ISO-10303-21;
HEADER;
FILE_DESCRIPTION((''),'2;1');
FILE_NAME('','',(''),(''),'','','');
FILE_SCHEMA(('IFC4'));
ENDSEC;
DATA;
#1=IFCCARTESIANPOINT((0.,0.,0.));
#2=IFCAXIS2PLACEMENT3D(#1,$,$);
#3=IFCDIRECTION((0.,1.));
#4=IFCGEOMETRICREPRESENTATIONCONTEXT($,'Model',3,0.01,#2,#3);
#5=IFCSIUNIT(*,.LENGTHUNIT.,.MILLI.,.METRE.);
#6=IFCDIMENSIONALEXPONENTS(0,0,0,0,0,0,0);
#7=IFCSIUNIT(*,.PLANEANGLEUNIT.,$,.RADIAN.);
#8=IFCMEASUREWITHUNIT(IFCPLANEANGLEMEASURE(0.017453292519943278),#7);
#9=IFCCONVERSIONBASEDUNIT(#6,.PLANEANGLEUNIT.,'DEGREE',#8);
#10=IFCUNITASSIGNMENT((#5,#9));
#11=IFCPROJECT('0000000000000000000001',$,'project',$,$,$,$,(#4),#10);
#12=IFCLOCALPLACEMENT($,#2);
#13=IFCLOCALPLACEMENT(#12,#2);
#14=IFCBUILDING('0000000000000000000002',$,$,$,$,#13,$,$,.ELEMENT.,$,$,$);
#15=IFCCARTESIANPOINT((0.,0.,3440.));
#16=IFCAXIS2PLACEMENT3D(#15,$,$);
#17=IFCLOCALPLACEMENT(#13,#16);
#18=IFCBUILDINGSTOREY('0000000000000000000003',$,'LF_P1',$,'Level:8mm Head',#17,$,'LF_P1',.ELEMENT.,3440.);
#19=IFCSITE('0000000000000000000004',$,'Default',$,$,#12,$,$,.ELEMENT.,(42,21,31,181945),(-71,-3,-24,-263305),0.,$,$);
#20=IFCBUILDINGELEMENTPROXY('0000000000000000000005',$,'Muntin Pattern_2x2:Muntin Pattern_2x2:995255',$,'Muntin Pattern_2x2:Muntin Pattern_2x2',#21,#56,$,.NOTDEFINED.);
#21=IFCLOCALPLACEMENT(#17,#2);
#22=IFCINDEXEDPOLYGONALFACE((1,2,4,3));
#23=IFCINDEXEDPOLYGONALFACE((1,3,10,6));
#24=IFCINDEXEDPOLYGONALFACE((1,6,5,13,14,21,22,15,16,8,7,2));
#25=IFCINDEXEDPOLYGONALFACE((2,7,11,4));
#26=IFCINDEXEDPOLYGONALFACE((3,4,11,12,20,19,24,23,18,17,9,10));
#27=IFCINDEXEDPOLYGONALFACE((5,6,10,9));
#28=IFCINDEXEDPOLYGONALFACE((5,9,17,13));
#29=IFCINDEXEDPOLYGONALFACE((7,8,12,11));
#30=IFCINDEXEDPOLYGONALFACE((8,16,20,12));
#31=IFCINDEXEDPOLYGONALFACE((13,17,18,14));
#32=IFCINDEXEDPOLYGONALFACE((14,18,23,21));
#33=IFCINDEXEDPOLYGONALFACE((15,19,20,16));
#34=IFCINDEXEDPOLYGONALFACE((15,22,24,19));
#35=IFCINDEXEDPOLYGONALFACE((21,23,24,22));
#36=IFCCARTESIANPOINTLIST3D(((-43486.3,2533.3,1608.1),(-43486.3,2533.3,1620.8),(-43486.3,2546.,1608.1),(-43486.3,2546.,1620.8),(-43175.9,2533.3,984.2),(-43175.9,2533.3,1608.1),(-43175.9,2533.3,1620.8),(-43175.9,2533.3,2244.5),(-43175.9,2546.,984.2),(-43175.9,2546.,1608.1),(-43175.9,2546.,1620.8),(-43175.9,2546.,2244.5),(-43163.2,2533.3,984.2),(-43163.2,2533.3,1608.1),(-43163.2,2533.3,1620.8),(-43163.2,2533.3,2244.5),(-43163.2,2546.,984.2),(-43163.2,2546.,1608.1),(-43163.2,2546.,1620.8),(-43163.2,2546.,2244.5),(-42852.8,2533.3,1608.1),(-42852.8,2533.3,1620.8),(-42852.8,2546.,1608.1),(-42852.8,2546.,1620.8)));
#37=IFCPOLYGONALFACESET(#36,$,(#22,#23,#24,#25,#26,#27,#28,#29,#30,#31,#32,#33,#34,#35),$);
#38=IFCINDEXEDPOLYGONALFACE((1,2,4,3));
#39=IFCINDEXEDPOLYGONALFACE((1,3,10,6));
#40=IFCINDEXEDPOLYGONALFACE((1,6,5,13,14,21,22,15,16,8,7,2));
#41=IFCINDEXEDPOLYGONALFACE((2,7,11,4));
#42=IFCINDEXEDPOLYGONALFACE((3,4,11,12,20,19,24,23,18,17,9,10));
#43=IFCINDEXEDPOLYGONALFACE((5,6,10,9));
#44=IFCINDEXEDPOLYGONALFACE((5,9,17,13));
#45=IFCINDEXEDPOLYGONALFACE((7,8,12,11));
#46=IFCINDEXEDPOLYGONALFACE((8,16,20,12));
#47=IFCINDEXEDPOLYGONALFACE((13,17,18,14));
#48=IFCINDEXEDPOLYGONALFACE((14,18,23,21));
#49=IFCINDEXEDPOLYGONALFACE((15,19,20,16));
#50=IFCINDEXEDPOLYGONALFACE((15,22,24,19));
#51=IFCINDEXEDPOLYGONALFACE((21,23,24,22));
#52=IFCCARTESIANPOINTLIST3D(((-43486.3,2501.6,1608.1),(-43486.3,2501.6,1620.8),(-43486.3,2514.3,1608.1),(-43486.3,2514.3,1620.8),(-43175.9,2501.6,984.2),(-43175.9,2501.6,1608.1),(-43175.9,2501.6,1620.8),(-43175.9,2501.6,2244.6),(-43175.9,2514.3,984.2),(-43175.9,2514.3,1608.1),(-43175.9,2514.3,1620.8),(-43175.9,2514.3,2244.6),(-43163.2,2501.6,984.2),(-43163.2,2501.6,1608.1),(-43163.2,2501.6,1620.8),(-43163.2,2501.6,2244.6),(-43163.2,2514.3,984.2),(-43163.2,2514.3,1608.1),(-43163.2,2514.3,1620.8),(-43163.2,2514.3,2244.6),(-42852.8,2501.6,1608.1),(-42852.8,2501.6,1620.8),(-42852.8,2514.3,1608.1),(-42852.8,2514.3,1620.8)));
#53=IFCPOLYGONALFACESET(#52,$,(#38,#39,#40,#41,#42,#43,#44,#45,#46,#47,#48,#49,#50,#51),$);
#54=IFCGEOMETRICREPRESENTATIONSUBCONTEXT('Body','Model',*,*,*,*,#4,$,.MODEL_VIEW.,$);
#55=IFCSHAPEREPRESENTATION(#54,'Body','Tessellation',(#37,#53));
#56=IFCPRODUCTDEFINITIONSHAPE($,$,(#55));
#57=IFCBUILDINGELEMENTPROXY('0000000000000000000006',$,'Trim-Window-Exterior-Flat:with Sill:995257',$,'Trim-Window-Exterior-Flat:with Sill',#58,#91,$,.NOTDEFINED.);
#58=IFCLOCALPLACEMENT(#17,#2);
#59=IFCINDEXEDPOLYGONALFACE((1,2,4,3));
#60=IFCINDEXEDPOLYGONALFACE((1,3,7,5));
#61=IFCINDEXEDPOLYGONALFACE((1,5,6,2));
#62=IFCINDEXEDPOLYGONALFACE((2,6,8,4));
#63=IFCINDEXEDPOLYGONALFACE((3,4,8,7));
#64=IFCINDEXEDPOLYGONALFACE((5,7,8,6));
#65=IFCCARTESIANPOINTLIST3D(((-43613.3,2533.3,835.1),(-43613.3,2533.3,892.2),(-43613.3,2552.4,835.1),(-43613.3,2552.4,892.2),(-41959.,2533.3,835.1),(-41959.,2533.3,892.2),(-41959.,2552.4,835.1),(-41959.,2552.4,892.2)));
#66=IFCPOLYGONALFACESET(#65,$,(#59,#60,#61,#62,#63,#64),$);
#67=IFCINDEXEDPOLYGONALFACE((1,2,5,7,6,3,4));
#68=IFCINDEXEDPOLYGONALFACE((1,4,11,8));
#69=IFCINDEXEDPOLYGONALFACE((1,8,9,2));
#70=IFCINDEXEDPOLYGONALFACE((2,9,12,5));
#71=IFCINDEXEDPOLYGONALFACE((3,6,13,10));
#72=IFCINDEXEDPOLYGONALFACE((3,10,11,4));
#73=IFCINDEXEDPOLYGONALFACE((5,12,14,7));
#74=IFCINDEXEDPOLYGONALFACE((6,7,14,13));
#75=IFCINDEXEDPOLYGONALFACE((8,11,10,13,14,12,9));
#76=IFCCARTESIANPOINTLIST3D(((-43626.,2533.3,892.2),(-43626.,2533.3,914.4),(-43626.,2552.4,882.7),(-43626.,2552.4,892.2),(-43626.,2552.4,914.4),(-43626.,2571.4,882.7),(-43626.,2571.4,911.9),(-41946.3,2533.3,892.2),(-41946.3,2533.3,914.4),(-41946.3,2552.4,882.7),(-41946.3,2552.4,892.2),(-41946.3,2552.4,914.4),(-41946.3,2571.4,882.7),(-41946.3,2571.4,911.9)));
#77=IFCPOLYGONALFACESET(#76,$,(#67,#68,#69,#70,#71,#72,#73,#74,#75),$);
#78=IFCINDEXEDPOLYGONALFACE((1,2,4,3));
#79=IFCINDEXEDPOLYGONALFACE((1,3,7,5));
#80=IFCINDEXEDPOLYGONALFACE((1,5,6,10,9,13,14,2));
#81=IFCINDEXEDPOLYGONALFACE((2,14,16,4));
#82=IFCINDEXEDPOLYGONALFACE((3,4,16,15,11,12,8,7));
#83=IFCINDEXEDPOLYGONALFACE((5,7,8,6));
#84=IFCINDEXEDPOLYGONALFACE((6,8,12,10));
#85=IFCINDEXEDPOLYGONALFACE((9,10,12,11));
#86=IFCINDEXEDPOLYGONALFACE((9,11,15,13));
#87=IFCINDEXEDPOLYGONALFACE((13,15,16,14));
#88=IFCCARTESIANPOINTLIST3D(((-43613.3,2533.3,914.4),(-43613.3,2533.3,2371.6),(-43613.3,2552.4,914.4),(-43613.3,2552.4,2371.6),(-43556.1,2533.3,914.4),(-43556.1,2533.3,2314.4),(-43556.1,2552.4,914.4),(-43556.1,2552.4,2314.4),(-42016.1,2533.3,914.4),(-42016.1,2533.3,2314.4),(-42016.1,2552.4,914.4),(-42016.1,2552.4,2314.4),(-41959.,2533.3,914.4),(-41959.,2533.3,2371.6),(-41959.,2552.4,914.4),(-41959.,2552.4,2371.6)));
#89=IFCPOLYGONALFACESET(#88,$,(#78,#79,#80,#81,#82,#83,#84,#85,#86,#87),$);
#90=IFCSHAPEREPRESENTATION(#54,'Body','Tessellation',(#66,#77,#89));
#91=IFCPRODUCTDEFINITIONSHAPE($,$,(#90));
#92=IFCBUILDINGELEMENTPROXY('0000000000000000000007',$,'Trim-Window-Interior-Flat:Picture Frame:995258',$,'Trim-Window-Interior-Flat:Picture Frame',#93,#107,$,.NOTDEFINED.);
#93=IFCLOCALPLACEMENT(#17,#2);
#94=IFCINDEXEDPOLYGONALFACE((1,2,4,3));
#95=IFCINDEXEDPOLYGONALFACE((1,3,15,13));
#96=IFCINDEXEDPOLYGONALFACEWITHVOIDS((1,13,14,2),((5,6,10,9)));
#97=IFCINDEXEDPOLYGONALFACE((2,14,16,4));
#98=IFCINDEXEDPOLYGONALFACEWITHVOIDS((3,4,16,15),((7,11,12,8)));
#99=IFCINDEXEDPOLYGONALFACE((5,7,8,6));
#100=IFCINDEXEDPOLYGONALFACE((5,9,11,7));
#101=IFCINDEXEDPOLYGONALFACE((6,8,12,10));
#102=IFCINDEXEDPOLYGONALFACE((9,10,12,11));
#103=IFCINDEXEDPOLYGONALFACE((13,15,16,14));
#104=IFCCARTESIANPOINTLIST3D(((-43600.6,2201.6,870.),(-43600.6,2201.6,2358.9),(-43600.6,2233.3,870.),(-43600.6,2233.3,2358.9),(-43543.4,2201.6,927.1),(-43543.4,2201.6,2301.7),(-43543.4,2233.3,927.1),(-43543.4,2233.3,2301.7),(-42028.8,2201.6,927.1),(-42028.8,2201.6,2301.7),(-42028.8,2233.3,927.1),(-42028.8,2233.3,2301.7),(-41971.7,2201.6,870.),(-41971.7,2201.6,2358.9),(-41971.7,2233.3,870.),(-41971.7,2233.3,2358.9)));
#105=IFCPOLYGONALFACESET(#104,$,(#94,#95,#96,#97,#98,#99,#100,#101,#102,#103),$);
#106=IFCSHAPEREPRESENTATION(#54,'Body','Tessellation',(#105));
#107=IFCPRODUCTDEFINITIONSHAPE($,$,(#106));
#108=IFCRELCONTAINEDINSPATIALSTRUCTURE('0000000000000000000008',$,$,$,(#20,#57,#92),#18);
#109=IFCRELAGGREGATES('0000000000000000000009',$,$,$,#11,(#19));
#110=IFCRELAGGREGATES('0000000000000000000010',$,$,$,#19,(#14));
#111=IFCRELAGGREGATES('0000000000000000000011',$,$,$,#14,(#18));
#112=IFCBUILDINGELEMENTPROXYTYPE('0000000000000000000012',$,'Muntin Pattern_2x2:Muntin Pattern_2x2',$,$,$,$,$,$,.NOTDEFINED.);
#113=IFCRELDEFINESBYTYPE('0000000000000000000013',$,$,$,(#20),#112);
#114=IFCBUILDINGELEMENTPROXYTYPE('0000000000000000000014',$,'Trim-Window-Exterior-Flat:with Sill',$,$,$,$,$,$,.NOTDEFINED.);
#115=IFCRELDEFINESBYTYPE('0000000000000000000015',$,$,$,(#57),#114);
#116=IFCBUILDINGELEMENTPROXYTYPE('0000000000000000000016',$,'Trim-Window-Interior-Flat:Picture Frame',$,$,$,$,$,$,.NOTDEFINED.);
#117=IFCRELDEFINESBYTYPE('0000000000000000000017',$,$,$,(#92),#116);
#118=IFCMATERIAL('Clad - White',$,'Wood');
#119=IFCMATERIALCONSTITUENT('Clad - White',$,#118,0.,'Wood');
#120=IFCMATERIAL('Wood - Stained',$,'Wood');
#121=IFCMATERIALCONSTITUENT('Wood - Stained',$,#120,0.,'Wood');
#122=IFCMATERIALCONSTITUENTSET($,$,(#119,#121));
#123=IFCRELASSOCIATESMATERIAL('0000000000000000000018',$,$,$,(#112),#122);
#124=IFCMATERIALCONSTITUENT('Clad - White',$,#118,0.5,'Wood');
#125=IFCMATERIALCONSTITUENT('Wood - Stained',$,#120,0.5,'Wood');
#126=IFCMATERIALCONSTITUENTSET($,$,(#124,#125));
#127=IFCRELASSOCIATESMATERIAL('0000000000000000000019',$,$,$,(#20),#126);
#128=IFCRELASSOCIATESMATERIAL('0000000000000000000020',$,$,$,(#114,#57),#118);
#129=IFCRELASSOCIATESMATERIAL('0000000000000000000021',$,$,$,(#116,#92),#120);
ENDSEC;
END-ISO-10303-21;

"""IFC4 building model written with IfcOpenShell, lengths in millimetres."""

from ifc_helpers import new_model, entity, si_unit, converted_unit, direction, frame, origin, place, context, subcontext, project, spatial, indexed_curve, outline, extrude, source, transform, mapped, material, constituent, constituent_set, type_object, type_shapes, element, save


model = new_model("IFC4")

# Units and contexts
model_context = context("Model", 3, precision=0.01, world=origin(), true_north=direction((0.0, 1.0)))
body_context = subcontext(model_context, "Body", "Model", "MODEL_VIEW")
ifc_project = project(units=[si_unit("LENGTHUNIT", "METRE", prefix="MILLI"), converted_unit("PLANEANGLEUNIT", "DEGREE", entity("IfcPlaneAngleMeasure", 0.017453292519943278), si_unit("PLANEANGLEUNIT", "RADIAN"), dimensions=[0, 0, 0, 0, 0, 0, 0])], contexts=[model_context])

# Site, building, storey
site_placement = place(None, origin())
site = spatial("IfcSite", under=ifc_project, at=site_placement, Name="Default", CompositionType="ELEMENT", RefLatitude=(42, 21, 31, 181945), RefLongitude=(-71, -3, -24, -263305), RefElevation=0.0)
building_placement = place(site_placement, origin())
building = spatial("IfcBuilding", under=site, at=building_placement, CompositionType="ELEMENT")
storey_placement = place(building_placement, frame((0.0, 0.0, 3440.0)))
storey = spatial("IfcBuildingStorey", under=building, at=storey_placement, Name="LF_P1", ObjectType="Level:8mm Head", LongName="LF_P1", CompositionType="ELEMENT", Elevation=3440.0)

# Building element proxies
ifc_material_1 = material(Name="Clad - White", Category="Wood")
ifc_material_2 = material(Name="Wood - Stained", Category="Wood")
ifc_constituent_1 = constituent(ifc_material_1, Name="Clad - White", Category="Wood", fraction=0.5)
ifc_constituent_2 = constituent(ifc_material_2, Name="Wood - Stained", Category="Wood", fraction=0.5)
ifc_constituent_set_1 = constituent_set(constituents=[ifc_constituent_1, ifc_constituent_2])
ifc_constituent_3 = constituent(ifc_material_1, Name="Clad - White", Category="Wood", fraction=0.0)
ifc_constituent_4 = constituent(ifc_material_2, Name="Wood - Stained", Category="Wood", fraction=0.0)
ifc_constituent_set_2 = constituent_set(constituents=[ifc_constituent_3, ifc_constituent_4])
building_element_proxy_type_1 = type_object("IfcBuildingElementProxyType", Name="Muntin Pattern_2x2:Muntin Pattern_2x2", PredefinedType="NOTDEFINED", material=ifc_constituent_set_2)
shared_shape_1 = source(origin(), body_context, "Body", "SweptSolid", [
    extrude(outline(indexed_curve([(6.4, -6.4), (630.1, -6.4), (630.1, 6.3), (6.4, 6.3), (6.4, 316.7), (-6.3, 316.7), (-6.3, 6.3), (-630.2, 6.3), (-630.2, -6.4), (-6.3, -6.4), (-6.3, -316.7), (6.4, -316.7), (6.4, -6.4)], self_intersect=False)), frame((0.0, 9.5, 630.1), z_axis=(0.0, 1.0, 0.0), x_axis=(0.0, 0.0, 1.0)), (0.0, 0.0, 1.0), 12.7),
    extrude(outline(indexed_curve([(6.4, -6.4), (630.2, -6.4), (630.2, 6.3), (6.4, 6.3), (6.4, 316.7), (-6.3, 316.7), (-6.3, 6.3), (-630.2, 6.3), (-630.2, -6.4), (-6.3, -6.4), (-6.3, -316.7), (6.4, -316.7), (6.4, -6.4)], self_intersect=False)), frame((0.0, -22.2, 630.2), z_axis=(0.0, 1.0, 0.0), x_axis=(0.0, 0.0, 1.0)), (0.0, 0.0, 1.0), 12.7),
])
type_shapes(building_element_proxy_type_1, [shared_shape_1])
proxy_1_placement = place(storey_placement, frame((-43169.5, 2523.8, 984.3)))
element("IfcBuildingElementProxy", 1, at=proxy_1_placement, inside=storey, type_object=building_element_proxy_type_1, material=ifc_constituent_set_1, Name="Muntin Pattern_2x2:Muntin Pattern_2x2:995255", ObjectType="Muntin Pattern_2x2:Muntin Pattern_2x2", PredefinedType="NOTDEFINED", context=body_context, shape_type="MappedRepresentation", body=[
    mapped(shared_shape_1, transform((0.0, 0.0, 0.0), scale=1.0)),
])
building_element_proxy_type_2 = type_object("IfcBuildingElementProxyType", Name="Trim-Window-Exterior-Flat:with Sill", PredefinedType="NOTDEFINED", material=ifc_material_1)
shared_shape_2 = source(origin(), body_context, "Body", "SweptSolid", [
    extrude(outline(indexed_curve([(-827.1, -28.6), (827.1, -28.6), (827.1, 28.6), (-827.1, 28.6), (-827.1, -28.6)], self_intersect=False)), frame((0.0, -1450.8, 0.0), z_axis=(0.0, 0.0, 1.0), x_axis=(-1.0, 0.0, 0.0)), (0.0, 0.0, 1.0), 19.0),
    extrude(outline(indexed_curve([(-19.0, -16.0), (0.0, -16.0), (0.0, -6.4), (19.0, -6.4), (19.0, 15.8), (0.0, 15.8), (-19.0, 13.3), (-19.0, -16.0)], self_intersect=False)), frame((-839.8, -1415.8, 19.0), z_axis=(1.0, 0.0, 0.0), x_axis=(0.0, 0.0, -1.0)), (0.0, 0.0, 1.0), 1679.7),
    extrude(outline(indexed_curve([(-742.9, -827.1), (714.3, -827.1), (714.3, -770.0), (-685.7, -770.0), (-685.7, 770.0), (714.3, 770.0), (714.3, 827.1), (-742.9, 827.1), (-742.9, -827.1)], self_intersect=False)), frame((0.0, -685.7, 0.0), z_axis=(0.0, 0.0, 1.0), x_axis=(0.0, -1.0, 0.0)), (0.0, 0.0, 1.0), 19.0),
])
type_shapes(building_element_proxy_type_2, [shared_shape_2])
proxy_2_placement = place(storey_placement, frame((-42786.1, 2533.3, 2314.4), z_axis=(0.0, 1.0, 0.0), x_axis=(-1.0, 0.0, 0.0)))
element("IfcBuildingElementProxy", 2, at=proxy_2_placement, inside=storey, type_object=building_element_proxy_type_2, material=ifc_material_1, Name="Trim-Window-Exterior-Flat:with Sill:995257", ObjectType="Trim-Window-Exterior-Flat:with Sill", PredefinedType="NOTDEFINED", context=body_context, shape_type="MappedRepresentation", body=[
    mapped(shared_shape_2, transform((0.0, 0.0, 0.0), scale=1.0)),
])
building_element_proxy_type_3 = type_object("IfcBuildingElementProxyType", Name="Trim-Window-Interior-Flat:Picture Frame", PredefinedType="NOTDEFINED", material=ifc_material_2)
shared_shape_3 = source(origin(), body_context, "Body", "SweptSolid", [
    extrude(outline(indexed_curve([(-814.4, -744.4), (814.4, -744.4), (814.4, 744.4), (-814.4, 744.4), (-814.4, -744.4)], self_intersect=False), holes=[indexed_curve([(-757.3, -687.3), (-757.3, 687.3), (757.3, 687.3), (757.3, -687.3), (-757.3, -687.3)], self_intersect=False)]), frame((0.0, -700.0, 0.0), z_axis=(0.0, 0.0, 1.0), x_axis=(-1.0, 0.0, 0.0)), (0.0, 0.0, 1.0), 31.7),
])
type_shapes(building_element_proxy_type_3, [shared_shape_3])
proxy_3_placement = place(storey_placement, frame((-42786.1, 2233.3, 2314.4), z_axis=(0.0, -1.0, 0.0), x_axis=(1.0, 0.0, 0.0)))
element("IfcBuildingElementProxy", 3, at=proxy_3_placement, inside=storey, type_object=building_element_proxy_type_3, material=ifc_material_2, Name="Trim-Window-Interior-Flat:Picture Frame:995258", ObjectType="Trim-Window-Interior-Flat:Picture Frame", PredefinedType="NOTDEFINED", context=body_context, shape_type="MappedRepresentation", body=[
    mapped(shared_shape_3, transform((0.0, 0.0, 0.0), scale=1.0)),
])

save(model, "model.ifc")
